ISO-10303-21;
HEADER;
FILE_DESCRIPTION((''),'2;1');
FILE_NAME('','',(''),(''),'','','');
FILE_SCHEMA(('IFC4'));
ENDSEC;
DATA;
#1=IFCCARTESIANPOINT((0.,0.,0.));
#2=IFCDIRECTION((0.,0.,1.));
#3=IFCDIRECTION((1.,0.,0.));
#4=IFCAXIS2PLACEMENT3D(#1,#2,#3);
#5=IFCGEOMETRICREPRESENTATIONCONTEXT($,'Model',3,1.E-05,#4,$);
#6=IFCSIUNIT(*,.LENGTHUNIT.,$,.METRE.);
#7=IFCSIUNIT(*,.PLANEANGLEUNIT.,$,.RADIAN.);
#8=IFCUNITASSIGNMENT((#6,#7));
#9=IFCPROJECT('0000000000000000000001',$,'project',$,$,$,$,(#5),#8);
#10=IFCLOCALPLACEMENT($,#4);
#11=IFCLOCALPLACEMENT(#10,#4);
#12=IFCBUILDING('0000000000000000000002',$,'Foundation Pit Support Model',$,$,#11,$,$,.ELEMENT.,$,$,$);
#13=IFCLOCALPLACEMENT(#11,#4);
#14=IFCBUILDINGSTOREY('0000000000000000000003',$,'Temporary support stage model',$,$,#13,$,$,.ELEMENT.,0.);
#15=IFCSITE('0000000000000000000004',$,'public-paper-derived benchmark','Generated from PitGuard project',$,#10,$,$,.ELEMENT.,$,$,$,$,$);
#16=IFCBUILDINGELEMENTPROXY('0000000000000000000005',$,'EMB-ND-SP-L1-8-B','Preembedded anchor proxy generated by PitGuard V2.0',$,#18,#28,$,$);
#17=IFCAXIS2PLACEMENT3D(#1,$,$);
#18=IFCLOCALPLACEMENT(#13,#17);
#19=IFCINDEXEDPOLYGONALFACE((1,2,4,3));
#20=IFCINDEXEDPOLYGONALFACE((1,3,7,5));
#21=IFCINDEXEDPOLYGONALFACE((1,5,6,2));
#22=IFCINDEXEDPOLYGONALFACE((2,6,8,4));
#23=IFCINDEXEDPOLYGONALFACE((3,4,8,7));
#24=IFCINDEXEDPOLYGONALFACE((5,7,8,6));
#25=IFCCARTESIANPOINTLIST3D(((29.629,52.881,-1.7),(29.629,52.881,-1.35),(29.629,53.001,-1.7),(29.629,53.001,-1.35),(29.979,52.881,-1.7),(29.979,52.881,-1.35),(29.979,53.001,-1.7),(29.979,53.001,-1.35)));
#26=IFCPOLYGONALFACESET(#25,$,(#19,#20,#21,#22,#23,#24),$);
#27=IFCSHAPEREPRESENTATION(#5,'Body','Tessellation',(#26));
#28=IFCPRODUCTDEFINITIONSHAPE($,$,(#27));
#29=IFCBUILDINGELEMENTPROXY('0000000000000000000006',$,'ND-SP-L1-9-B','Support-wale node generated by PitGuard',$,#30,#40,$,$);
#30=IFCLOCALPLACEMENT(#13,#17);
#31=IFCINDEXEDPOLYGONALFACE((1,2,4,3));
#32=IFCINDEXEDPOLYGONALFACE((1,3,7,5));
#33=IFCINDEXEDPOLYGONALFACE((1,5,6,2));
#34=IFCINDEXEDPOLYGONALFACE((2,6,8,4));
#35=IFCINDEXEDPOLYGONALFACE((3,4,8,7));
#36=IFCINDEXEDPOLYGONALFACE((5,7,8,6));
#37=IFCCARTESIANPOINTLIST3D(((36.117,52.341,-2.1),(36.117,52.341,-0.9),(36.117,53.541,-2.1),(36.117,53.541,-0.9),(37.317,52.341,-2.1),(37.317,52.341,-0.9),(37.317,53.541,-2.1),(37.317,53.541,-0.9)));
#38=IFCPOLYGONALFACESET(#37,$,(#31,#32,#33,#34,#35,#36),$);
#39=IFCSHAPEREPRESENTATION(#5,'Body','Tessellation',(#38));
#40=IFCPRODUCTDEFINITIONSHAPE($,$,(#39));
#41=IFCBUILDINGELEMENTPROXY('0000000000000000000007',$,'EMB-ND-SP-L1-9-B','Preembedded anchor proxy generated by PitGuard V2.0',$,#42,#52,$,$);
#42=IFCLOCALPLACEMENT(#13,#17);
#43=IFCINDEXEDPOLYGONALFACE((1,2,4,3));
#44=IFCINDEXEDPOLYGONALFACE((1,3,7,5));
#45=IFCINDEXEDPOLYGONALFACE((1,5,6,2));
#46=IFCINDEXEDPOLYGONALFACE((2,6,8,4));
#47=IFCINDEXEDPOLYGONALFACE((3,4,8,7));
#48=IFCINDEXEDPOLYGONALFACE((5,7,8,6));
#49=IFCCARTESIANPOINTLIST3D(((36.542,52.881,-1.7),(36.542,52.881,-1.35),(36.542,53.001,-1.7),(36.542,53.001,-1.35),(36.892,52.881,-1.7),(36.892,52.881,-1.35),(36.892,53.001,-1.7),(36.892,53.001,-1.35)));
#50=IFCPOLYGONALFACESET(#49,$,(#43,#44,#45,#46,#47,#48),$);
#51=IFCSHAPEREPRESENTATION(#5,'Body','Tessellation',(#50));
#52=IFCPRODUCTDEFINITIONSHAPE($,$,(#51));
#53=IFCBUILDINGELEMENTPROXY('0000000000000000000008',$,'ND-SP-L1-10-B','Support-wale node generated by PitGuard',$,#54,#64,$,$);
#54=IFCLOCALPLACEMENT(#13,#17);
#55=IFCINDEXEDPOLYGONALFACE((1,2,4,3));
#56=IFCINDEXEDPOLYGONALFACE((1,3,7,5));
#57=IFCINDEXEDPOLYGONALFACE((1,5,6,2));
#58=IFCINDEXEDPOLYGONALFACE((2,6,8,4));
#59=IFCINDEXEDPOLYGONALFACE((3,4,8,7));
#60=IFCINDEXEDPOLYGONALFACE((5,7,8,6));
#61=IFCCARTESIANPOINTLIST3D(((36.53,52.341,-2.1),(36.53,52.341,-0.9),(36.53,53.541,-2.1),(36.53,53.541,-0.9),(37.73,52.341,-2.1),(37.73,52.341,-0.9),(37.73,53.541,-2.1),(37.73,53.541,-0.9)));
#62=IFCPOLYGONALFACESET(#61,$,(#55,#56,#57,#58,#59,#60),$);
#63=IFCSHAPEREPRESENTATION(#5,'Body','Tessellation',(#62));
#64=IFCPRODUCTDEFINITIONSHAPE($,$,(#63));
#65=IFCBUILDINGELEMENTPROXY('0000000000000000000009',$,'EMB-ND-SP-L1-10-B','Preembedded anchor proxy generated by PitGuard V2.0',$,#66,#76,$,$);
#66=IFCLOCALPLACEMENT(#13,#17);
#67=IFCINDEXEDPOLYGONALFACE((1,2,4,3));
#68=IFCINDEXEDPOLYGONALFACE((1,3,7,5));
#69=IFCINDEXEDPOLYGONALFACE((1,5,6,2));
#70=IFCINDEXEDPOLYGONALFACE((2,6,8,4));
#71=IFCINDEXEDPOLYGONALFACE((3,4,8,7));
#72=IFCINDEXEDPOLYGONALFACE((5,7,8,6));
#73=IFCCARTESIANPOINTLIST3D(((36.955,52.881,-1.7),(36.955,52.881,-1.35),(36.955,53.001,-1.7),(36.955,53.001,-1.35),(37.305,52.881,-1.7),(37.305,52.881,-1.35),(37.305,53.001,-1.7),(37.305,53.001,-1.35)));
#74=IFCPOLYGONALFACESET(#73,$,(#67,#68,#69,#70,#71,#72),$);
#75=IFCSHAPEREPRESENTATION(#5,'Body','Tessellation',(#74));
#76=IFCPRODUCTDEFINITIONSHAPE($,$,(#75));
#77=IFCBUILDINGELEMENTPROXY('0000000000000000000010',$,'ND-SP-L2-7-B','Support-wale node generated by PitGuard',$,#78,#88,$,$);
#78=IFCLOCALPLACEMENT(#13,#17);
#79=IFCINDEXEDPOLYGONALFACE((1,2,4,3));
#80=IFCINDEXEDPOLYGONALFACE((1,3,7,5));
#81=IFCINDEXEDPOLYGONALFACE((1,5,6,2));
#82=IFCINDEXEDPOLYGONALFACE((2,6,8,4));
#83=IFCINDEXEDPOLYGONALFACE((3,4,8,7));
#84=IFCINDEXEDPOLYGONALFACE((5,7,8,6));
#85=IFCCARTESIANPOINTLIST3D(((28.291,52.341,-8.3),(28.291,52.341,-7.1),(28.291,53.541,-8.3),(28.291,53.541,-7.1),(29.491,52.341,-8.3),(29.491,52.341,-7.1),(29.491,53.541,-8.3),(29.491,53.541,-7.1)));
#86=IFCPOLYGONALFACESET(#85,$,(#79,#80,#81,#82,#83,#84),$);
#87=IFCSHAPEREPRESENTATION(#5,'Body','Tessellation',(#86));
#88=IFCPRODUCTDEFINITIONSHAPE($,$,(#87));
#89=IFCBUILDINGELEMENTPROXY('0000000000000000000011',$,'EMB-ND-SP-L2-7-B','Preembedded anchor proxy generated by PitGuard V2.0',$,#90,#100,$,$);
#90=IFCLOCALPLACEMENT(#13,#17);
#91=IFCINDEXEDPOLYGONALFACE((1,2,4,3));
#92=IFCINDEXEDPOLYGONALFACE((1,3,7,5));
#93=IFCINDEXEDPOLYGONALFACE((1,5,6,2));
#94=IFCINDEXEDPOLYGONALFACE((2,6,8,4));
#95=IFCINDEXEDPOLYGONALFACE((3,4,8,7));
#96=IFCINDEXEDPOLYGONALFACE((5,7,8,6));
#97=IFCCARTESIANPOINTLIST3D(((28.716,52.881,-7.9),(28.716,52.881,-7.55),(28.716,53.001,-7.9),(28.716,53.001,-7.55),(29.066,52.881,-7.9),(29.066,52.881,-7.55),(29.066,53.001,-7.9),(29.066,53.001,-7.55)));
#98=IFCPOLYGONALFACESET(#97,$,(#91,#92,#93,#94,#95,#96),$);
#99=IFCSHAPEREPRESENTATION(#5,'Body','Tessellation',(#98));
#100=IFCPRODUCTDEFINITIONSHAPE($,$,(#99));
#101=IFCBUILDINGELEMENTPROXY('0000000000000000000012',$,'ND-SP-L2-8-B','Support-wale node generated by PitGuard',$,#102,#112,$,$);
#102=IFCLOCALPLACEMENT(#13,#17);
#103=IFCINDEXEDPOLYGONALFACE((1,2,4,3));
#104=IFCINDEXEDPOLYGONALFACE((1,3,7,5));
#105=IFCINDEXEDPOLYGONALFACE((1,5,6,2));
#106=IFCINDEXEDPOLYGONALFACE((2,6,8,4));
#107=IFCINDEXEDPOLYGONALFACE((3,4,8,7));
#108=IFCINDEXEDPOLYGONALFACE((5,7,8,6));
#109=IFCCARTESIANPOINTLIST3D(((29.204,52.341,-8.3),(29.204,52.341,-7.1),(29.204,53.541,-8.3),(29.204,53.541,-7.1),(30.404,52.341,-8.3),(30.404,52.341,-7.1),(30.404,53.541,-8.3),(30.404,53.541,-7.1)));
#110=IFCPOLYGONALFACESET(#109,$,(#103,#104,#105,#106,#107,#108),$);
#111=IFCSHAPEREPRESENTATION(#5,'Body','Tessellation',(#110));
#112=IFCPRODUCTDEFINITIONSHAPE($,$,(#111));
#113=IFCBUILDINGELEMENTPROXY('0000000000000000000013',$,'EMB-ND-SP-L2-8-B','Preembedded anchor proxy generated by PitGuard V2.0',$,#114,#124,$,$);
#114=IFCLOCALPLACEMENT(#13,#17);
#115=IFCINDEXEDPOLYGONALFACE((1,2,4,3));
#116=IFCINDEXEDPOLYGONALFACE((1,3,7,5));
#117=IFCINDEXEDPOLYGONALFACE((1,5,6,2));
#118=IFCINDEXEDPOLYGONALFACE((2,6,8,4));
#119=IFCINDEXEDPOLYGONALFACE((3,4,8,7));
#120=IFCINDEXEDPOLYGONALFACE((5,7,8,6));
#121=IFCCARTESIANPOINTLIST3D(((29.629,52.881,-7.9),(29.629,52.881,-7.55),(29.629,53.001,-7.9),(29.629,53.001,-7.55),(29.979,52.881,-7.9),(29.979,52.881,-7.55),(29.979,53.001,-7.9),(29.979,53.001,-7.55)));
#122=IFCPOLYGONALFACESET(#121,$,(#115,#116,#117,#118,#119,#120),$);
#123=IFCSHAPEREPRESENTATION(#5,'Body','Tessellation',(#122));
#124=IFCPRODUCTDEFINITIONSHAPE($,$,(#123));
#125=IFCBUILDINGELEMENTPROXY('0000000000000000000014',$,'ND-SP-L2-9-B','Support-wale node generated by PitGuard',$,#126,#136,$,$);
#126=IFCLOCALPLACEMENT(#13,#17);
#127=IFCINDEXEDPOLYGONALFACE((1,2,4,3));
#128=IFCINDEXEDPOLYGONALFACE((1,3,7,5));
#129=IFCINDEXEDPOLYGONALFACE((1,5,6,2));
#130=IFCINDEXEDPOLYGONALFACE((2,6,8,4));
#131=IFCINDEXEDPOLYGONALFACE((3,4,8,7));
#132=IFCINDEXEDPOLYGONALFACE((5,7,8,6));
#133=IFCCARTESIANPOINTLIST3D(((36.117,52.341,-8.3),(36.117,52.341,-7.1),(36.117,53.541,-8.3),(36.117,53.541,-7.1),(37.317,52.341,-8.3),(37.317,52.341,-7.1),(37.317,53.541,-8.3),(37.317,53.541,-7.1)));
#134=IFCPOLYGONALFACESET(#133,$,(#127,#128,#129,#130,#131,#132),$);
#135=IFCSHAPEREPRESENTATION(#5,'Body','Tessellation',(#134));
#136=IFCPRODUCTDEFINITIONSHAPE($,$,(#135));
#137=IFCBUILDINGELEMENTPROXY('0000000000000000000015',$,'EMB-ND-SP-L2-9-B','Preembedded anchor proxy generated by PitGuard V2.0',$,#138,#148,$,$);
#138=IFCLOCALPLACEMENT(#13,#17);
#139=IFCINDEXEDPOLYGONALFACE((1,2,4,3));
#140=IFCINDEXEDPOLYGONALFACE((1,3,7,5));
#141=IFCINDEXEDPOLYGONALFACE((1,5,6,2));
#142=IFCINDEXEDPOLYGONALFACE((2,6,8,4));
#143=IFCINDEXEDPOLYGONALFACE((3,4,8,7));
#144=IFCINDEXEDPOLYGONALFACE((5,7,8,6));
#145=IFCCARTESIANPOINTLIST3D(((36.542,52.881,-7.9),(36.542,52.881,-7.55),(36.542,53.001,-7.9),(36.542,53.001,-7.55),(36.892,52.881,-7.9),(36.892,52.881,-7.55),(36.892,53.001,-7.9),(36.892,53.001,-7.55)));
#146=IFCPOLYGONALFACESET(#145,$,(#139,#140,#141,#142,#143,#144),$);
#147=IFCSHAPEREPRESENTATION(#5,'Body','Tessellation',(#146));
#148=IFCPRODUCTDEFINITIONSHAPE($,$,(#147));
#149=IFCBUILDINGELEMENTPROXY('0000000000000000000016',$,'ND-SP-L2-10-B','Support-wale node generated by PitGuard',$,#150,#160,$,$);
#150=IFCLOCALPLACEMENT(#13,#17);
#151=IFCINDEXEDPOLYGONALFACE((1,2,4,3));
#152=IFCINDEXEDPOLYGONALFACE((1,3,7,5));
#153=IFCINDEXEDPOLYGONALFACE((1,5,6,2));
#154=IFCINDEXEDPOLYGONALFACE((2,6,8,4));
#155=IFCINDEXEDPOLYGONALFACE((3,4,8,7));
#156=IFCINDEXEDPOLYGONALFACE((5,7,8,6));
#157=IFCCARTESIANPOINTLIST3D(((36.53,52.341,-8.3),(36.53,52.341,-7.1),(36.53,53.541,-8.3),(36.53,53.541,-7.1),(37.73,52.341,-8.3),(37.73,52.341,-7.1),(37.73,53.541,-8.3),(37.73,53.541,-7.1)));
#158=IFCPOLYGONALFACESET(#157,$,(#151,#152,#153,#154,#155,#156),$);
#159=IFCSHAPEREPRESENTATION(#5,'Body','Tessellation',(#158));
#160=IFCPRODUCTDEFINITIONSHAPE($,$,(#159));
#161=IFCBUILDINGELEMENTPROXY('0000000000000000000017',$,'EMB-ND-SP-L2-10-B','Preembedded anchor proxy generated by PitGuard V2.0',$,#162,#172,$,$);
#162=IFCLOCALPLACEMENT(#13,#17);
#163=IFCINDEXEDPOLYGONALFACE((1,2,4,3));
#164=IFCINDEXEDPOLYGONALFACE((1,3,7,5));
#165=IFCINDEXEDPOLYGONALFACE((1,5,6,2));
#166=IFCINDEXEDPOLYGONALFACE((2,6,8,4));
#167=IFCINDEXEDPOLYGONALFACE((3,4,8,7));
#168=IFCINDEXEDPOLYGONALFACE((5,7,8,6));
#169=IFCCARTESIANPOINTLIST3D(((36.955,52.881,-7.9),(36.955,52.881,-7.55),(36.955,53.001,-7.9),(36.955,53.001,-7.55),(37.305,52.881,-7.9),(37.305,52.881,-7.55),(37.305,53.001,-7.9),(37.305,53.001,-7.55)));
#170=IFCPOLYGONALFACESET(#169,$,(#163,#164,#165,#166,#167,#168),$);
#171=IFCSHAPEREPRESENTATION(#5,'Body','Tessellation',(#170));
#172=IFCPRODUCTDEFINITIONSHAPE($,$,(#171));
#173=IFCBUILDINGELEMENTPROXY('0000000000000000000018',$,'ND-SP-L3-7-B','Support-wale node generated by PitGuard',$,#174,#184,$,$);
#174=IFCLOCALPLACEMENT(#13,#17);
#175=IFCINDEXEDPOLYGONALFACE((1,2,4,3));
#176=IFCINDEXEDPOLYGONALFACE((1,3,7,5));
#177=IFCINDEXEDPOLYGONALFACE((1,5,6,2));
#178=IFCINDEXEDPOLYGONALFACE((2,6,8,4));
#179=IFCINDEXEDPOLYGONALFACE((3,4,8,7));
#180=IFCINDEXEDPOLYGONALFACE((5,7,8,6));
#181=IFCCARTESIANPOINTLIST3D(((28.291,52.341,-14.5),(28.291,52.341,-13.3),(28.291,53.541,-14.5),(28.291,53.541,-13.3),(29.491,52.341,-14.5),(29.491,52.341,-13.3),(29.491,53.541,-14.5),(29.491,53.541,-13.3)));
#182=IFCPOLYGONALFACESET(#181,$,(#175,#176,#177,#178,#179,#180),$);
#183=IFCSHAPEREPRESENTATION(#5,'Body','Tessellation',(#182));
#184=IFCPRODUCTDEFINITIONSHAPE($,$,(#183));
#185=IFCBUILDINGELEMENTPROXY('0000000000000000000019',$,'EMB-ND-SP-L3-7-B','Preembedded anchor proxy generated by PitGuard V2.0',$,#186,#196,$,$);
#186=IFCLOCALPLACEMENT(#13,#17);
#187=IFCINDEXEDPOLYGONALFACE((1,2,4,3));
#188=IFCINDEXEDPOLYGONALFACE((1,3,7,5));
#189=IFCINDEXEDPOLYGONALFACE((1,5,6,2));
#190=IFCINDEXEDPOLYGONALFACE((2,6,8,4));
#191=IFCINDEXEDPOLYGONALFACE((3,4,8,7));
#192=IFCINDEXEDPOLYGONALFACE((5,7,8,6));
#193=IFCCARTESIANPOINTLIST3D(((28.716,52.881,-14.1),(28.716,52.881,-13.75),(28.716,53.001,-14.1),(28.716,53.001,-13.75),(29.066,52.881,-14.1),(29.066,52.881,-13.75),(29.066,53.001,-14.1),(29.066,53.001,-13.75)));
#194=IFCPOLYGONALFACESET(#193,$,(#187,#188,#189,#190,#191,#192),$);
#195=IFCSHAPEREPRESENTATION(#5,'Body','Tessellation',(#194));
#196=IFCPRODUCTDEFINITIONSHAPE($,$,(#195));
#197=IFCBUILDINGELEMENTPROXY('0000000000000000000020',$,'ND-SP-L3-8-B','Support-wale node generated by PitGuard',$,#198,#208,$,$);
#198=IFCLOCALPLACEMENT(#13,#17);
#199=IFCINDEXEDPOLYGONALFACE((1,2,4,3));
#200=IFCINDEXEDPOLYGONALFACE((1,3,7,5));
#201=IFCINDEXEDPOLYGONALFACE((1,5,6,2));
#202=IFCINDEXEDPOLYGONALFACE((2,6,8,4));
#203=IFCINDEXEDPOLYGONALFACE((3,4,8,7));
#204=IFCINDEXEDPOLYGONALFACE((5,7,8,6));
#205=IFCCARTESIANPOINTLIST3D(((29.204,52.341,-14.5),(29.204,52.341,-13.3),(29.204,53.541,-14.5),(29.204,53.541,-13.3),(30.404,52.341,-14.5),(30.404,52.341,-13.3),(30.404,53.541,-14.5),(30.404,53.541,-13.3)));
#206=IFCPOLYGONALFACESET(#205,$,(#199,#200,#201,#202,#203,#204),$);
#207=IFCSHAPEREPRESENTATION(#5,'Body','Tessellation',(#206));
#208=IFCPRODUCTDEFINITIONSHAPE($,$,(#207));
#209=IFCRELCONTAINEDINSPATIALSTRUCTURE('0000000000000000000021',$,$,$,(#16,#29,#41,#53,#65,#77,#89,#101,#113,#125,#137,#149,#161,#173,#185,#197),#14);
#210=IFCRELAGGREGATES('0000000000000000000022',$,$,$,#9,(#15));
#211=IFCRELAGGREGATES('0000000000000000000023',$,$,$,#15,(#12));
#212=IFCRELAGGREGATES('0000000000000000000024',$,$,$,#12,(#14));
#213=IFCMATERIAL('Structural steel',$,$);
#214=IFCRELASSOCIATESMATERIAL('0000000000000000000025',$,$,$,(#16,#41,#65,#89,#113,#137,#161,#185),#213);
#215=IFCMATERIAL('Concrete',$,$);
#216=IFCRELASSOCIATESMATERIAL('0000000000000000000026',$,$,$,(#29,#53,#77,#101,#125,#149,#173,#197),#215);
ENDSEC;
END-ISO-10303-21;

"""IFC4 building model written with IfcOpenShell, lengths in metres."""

from ifc_helpers import new_model, si_unit, frame, origin_with_axes, origin_2d, place, context, project, spatial, rectangle, extrude, material, element, save


model = new_model("IFC4")

# Units and contexts
model_context = context("Model", 3, precision=1e-05, world=origin_with_axes())
ifc_project = project(units=[si_unit("LENGTHUNIT", "METRE"), si_unit("PLANEANGLEUNIT", "RADIAN")], contexts=[model_context])

# Site, building, storey
site_placement = place(None, origin_with_axes())
site = spatial("IfcSite", under=ifc_project, at=site_placement, Name="public-paper-derived benchmark", Description="Generated from PitGuard project", CompositionType="ELEMENT")
building_placement = place(site_placement, origin_with_axes())
building = spatial("IfcBuilding", under=site, at=building_placement, Name="Foundation Pit Support Model", CompositionType="ELEMENT")
storey_placement = place(building_placement, origin_with_axes())
storey = spatial("IfcBuildingStorey", under=building, at=storey_placement, Name="Temporary support stage model", CompositionType="ELEMENT", Elevation=0.0)

# Shared definitions
ifc_material_1 = material(Name="Structural steel")

# Shared definitions
ifc_material_2 = material(Name="Concrete")

# Building element proxies
proxy_1_placement = place(storey_placement, frame((29.804, 52.941, -1.7), z_axis=(0.0, 0.0, 1.0), x_axis=(1.0, 0.0, 0.0)))
element("IfcBuildingElementProxy", 1, at=proxy_1_placement, inside=storey, material=ifc_material_1, Name="EMB-ND-SP-L1-8-B", Description="Preembedded anchor proxy generated by PitGuard V2.0", context=model_context, shape_type="SweptSolid", body=[
    extrude(rectangle(XDim=0.35, YDim=0.12, at=origin_2d()), origin_with_axes(), (0.0, 0.0, 1.0), 0.35),
])
proxy_2_placement = place(storey_placement, frame((36.717, 52.941, -2.1), z_axis=(0.0, 0.0, 1.0), x_axis=(1.0, 0.0, 0.0)))
element("IfcBuildingElementProxy", 2, at=proxy_2_placement, inside=storey, material=ifc_material_2, Name="ND-SP-L1-9-B", Description="Support-wale node generated by PitGuard", context=model_context, shape_type="SweptSolid", body=[
    extrude(rectangle(XDim=1.2, YDim=1.2, at=origin_2d()), origin_with_axes(), (0.0, 0.0, 1.0), 1.2),
])
proxy_3_placement = place(storey_placement, frame((36.717, 52.941, -1.7), z_axis=(0.0, 0.0, 1.0), x_axis=(1.0, 0.0, 0.0)))
element("IfcBuildingElementProxy", 3, at=proxy_3_placement, inside=storey, material=ifc_material_1, Name="EMB-ND-SP-L1-9-B", Description="Preembedded anchor proxy generated by PitGuard V2.0", context=model_context, shape_type="SweptSolid", body=[
    extrude(rectangle(XDim=0.35, YDim=0.12, at=origin_2d()), origin_with_axes(), (0.0, 0.0, 1.0), 0.35),
])
proxy_4_placement = place(storey_placement, frame((37.13, 52.941, -2.1), z_axis=(0.0, 0.0, 1.0), x_axis=(1.0, 0.0, 0.0)))
element("IfcBuildingElementProxy", 4, at=proxy_4_placement, inside=storey, material=ifc_material_2, Name="ND-SP-L1-10-B", Description="Support-wale node generated by PitGuard", context=model_context, shape_type="SweptSolid", body=[
    extrude(rectangle(XDim=1.2, YDim=1.2, at=origin_2d()), origin_with_axes(), (0.0, 0.0, 1.0), 1.2),
])
proxy_5_placement = place(storey_placement, frame((37.13, 52.941, -1.7), z_axis=(0.0, 0.0, 1.0), x_axis=(1.0, 0.0, 0.0)))
element("IfcBuildingElementProxy", 5, at=proxy_5_placement, inside=storey, material=ifc_material_1, Name="EMB-ND-SP-L1-10-B", Description="Preembedded anchor proxy generated by PitGuard V2.0", context=model_context, shape_type="SweptSolid", body=[
    extrude(rectangle(XDim=0.35, YDim=0.12, at=origin_2d()), origin_with_axes(), (0.0, 0.0, 1.0), 0.35),
])
proxy_6_placement = place(storey_placement, frame((28.891, 52.941, -8.3), z_axis=(0.0, 0.0, 1.0), x_axis=(1.0, 0.0, 0.0)))
element("IfcBuildingElementProxy", 6, at=proxy_6_placement, inside=storey, material=ifc_material_2, Name="ND-SP-L2-7-B", Description="Support-wale node generated by PitGuard", context=model_context, shape_type="SweptSolid", body=[
    extrude(rectangle(XDim=1.2, YDim=1.2, at=origin_2d()), origin_with_axes(), (0.0, 0.0, 1.0), 1.2),
])
proxy_7_placement = place(storey_placement, frame((28.891, 52.941, -7.9), z_axis=(0.0, 0.0, 1.0), x_axis=(1.0, 0.0, 0.0)))
element("IfcBuildingElementProxy", 7, at=proxy_7_placement, inside=storey, material=ifc_material_1, Name="EMB-ND-SP-L2-7-B", Description="Preembedded anchor proxy generated by PitGuard V2.0", context=model_context, shape_type="SweptSolid", body=[
    extrude(rectangle(XDim=0.35, YDim=0.12, at=origin_2d()), origin_with_axes(), (0.0, 0.0, 1.0), 0.35),
])
proxy_8_placement = place(storey_placement, frame((29.804, 52.941, -8.3), z_axis=(0.0, 0.0, 1.0), x_axis=(1.0, 0.0, 0.0)))
element("IfcBuildingElementProxy", 8, at=proxy_8_placement, inside=storey, material=ifc_material_2, Name="ND-SP-L2-8-B", Description="Support-wale node generated by PitGuard", context=model_context, shape_type="SweptSolid", body=[
    extrude(rectangle(XDim=1.2, YDim=1.2, at=origin_2d()), origin_with_axes(), (0.0, 0.0, 1.0), 1.2),
])
proxy_9_placement = place(storey_placement, frame((29.804, 52.941, -7.9), z_axis=(0.0, 0.0, 1.0), x_axis=(1.0, 0.0, 0.0)))
element("IfcBuildingElementProxy", 9, at=proxy_9_placement, inside=storey, material=ifc_material_1, Name="EMB-ND-SP-L2-8-B", Description="Preembedded anchor proxy generated by PitGuard V2.0", context=model_context, shape_type="SweptSolid", body=[
    extrude(rectangle(XDim=0.35, YDim=0.12, at=origin_2d()), origin_with_axes(), (0.0, 0.0, 1.0), 0.35),
])
proxy_10_placement = place(storey_placement, frame((36.717, 52.941, -8.3), z_axis=(0.0, 0.0, 1.0), x_axis=(1.0, 0.0, 0.0)))
element("IfcBuildingElementProxy", 10, at=proxy_10_placement, inside=storey, material=ifc_material_2, Name="ND-SP-L2-9-B", Description="Support-wale node generated by PitGuard", context=model_context, shape_type="SweptSolid", body=[
    extrude(rectangle(XDim=1.2, YDim=1.2, at=origin_2d()), origin_with_axes(), (0.0, 0.0, 1.0), 1.2),
])
proxy_11_placement = place(storey_placement, frame((36.717, 52.941, -7.9), z_axis=(0.0, 0.0, 1.0), x_axis=(1.0, 0.0, 0.0)))
element("IfcBuildingElementProxy", 11, at=proxy_11_placement, inside=storey, material=ifc_material_1, Name="EMB-ND-SP-L2-9-B", Description="Preembedded anchor proxy generated by PitGuard V2.0", context=model_context, shape_type="SweptSolid", body=[
    extrude(rectangle(XDim=0.35, YDim=0.12, at=origin_2d()), origin_with_axes(), (0.0, 0.0, 1.0), 0.35),
])
proxy_12_placement = place(storey_placement, frame((37.13, 52.941, -8.3), z_axis=(0.0, 0.0, 1.0), x_axis=(1.0, 0.0, 0.0)))
element("IfcBuildingElementProxy", 12, at=proxy_12_placement, inside=storey, material=ifc_material_2, Name="ND-SP-L2-10-B", Description="Support-wale node generated by PitGuard", context=model_context, shape_type="SweptSolid", body=[
    extrude(rectangle(XDim=1.2, YDim=1.2, at=origin_2d()), origin_with_axes(), (0.0, 0.0, 1.0), 1.2),
])
proxy_13_placement = place(storey_placement, frame((37.13, 52.941, -7.9), z_axis=(0.0, 0.0, 1.0), x_axis=(1.0, 0.0, 0.0)))
element("IfcBuildingElementProxy", 13, at=proxy_13_placement, inside=storey, material=ifc_material_1, Name="EMB-ND-SP-L2-10-B", Description="Preembedded anchor proxy generated by PitGuard V2.0", context=model_context, shape_type="SweptSolid", body=[
    extrude(rectangle(XDim=0.35, YDim=0.12, at=origin_2d()), origin_with_axes(), (0.0, 0.0, 1.0), 0.35),
])
proxy_14_placement = place(storey_placement, frame((28.891, 52.941, -14.5), z_axis=(0.0, 0.0, 1.0), x_axis=(1.0, 0.0, 0.0)))
element("IfcBuildingElementProxy", 14, at=proxy_14_placement, inside=storey, material=ifc_material_2, Name="ND-SP-L3-7-B", Description="Support-wale node generated by PitGuard", context=model_context, shape_type="SweptSolid", body=[
    extrude(rectangle(XDim=1.2, YDim=1.2, at=origin_2d()), origin_with_axes(), (0.0, 0.0, 1.0), 1.2),
])
proxy_15_placement = place(storey_placement, frame((28.891, 52.941, -14.1), z_axis=(0.0, 0.0, 1.0), x_axis=(1.0, 0.0, 0.0)))
element("IfcBuildingElementProxy", 15, at=proxy_15_placement, inside=storey, material=ifc_material_1, Name="EMB-ND-SP-L3-7-B", Description="Preembedded anchor proxy generated by PitGuard V2.0", context=model_context, shape_type="SweptSolid", body=[
    extrude(rectangle(XDim=0.35, YDim=0.12, at=origin_2d()), origin_with_axes(), (0.0, 0.0, 1.0), 0.35),
])
proxy_16_placement = place(storey_placement, frame((29.804, 52.941, -14.5), z_axis=(0.0, 0.0, 1.0), x_axis=(1.0, 0.0, 0.0)))
element("IfcBuildingElementProxy", 16, at=proxy_16_placement, inside=storey, material=ifc_material_2, Name="ND-SP-L3-8-B", Description="Support-wale node generated by PitGuard", context=model_context, shape_type="SweptSolid", body=[
    extrude(rectangle(XDim=1.2, YDim=1.2, at=origin_2d()), origin_with_axes(), (0.0, 0.0, 1.0), 1.2),
])

save(model, "model.ifc")
